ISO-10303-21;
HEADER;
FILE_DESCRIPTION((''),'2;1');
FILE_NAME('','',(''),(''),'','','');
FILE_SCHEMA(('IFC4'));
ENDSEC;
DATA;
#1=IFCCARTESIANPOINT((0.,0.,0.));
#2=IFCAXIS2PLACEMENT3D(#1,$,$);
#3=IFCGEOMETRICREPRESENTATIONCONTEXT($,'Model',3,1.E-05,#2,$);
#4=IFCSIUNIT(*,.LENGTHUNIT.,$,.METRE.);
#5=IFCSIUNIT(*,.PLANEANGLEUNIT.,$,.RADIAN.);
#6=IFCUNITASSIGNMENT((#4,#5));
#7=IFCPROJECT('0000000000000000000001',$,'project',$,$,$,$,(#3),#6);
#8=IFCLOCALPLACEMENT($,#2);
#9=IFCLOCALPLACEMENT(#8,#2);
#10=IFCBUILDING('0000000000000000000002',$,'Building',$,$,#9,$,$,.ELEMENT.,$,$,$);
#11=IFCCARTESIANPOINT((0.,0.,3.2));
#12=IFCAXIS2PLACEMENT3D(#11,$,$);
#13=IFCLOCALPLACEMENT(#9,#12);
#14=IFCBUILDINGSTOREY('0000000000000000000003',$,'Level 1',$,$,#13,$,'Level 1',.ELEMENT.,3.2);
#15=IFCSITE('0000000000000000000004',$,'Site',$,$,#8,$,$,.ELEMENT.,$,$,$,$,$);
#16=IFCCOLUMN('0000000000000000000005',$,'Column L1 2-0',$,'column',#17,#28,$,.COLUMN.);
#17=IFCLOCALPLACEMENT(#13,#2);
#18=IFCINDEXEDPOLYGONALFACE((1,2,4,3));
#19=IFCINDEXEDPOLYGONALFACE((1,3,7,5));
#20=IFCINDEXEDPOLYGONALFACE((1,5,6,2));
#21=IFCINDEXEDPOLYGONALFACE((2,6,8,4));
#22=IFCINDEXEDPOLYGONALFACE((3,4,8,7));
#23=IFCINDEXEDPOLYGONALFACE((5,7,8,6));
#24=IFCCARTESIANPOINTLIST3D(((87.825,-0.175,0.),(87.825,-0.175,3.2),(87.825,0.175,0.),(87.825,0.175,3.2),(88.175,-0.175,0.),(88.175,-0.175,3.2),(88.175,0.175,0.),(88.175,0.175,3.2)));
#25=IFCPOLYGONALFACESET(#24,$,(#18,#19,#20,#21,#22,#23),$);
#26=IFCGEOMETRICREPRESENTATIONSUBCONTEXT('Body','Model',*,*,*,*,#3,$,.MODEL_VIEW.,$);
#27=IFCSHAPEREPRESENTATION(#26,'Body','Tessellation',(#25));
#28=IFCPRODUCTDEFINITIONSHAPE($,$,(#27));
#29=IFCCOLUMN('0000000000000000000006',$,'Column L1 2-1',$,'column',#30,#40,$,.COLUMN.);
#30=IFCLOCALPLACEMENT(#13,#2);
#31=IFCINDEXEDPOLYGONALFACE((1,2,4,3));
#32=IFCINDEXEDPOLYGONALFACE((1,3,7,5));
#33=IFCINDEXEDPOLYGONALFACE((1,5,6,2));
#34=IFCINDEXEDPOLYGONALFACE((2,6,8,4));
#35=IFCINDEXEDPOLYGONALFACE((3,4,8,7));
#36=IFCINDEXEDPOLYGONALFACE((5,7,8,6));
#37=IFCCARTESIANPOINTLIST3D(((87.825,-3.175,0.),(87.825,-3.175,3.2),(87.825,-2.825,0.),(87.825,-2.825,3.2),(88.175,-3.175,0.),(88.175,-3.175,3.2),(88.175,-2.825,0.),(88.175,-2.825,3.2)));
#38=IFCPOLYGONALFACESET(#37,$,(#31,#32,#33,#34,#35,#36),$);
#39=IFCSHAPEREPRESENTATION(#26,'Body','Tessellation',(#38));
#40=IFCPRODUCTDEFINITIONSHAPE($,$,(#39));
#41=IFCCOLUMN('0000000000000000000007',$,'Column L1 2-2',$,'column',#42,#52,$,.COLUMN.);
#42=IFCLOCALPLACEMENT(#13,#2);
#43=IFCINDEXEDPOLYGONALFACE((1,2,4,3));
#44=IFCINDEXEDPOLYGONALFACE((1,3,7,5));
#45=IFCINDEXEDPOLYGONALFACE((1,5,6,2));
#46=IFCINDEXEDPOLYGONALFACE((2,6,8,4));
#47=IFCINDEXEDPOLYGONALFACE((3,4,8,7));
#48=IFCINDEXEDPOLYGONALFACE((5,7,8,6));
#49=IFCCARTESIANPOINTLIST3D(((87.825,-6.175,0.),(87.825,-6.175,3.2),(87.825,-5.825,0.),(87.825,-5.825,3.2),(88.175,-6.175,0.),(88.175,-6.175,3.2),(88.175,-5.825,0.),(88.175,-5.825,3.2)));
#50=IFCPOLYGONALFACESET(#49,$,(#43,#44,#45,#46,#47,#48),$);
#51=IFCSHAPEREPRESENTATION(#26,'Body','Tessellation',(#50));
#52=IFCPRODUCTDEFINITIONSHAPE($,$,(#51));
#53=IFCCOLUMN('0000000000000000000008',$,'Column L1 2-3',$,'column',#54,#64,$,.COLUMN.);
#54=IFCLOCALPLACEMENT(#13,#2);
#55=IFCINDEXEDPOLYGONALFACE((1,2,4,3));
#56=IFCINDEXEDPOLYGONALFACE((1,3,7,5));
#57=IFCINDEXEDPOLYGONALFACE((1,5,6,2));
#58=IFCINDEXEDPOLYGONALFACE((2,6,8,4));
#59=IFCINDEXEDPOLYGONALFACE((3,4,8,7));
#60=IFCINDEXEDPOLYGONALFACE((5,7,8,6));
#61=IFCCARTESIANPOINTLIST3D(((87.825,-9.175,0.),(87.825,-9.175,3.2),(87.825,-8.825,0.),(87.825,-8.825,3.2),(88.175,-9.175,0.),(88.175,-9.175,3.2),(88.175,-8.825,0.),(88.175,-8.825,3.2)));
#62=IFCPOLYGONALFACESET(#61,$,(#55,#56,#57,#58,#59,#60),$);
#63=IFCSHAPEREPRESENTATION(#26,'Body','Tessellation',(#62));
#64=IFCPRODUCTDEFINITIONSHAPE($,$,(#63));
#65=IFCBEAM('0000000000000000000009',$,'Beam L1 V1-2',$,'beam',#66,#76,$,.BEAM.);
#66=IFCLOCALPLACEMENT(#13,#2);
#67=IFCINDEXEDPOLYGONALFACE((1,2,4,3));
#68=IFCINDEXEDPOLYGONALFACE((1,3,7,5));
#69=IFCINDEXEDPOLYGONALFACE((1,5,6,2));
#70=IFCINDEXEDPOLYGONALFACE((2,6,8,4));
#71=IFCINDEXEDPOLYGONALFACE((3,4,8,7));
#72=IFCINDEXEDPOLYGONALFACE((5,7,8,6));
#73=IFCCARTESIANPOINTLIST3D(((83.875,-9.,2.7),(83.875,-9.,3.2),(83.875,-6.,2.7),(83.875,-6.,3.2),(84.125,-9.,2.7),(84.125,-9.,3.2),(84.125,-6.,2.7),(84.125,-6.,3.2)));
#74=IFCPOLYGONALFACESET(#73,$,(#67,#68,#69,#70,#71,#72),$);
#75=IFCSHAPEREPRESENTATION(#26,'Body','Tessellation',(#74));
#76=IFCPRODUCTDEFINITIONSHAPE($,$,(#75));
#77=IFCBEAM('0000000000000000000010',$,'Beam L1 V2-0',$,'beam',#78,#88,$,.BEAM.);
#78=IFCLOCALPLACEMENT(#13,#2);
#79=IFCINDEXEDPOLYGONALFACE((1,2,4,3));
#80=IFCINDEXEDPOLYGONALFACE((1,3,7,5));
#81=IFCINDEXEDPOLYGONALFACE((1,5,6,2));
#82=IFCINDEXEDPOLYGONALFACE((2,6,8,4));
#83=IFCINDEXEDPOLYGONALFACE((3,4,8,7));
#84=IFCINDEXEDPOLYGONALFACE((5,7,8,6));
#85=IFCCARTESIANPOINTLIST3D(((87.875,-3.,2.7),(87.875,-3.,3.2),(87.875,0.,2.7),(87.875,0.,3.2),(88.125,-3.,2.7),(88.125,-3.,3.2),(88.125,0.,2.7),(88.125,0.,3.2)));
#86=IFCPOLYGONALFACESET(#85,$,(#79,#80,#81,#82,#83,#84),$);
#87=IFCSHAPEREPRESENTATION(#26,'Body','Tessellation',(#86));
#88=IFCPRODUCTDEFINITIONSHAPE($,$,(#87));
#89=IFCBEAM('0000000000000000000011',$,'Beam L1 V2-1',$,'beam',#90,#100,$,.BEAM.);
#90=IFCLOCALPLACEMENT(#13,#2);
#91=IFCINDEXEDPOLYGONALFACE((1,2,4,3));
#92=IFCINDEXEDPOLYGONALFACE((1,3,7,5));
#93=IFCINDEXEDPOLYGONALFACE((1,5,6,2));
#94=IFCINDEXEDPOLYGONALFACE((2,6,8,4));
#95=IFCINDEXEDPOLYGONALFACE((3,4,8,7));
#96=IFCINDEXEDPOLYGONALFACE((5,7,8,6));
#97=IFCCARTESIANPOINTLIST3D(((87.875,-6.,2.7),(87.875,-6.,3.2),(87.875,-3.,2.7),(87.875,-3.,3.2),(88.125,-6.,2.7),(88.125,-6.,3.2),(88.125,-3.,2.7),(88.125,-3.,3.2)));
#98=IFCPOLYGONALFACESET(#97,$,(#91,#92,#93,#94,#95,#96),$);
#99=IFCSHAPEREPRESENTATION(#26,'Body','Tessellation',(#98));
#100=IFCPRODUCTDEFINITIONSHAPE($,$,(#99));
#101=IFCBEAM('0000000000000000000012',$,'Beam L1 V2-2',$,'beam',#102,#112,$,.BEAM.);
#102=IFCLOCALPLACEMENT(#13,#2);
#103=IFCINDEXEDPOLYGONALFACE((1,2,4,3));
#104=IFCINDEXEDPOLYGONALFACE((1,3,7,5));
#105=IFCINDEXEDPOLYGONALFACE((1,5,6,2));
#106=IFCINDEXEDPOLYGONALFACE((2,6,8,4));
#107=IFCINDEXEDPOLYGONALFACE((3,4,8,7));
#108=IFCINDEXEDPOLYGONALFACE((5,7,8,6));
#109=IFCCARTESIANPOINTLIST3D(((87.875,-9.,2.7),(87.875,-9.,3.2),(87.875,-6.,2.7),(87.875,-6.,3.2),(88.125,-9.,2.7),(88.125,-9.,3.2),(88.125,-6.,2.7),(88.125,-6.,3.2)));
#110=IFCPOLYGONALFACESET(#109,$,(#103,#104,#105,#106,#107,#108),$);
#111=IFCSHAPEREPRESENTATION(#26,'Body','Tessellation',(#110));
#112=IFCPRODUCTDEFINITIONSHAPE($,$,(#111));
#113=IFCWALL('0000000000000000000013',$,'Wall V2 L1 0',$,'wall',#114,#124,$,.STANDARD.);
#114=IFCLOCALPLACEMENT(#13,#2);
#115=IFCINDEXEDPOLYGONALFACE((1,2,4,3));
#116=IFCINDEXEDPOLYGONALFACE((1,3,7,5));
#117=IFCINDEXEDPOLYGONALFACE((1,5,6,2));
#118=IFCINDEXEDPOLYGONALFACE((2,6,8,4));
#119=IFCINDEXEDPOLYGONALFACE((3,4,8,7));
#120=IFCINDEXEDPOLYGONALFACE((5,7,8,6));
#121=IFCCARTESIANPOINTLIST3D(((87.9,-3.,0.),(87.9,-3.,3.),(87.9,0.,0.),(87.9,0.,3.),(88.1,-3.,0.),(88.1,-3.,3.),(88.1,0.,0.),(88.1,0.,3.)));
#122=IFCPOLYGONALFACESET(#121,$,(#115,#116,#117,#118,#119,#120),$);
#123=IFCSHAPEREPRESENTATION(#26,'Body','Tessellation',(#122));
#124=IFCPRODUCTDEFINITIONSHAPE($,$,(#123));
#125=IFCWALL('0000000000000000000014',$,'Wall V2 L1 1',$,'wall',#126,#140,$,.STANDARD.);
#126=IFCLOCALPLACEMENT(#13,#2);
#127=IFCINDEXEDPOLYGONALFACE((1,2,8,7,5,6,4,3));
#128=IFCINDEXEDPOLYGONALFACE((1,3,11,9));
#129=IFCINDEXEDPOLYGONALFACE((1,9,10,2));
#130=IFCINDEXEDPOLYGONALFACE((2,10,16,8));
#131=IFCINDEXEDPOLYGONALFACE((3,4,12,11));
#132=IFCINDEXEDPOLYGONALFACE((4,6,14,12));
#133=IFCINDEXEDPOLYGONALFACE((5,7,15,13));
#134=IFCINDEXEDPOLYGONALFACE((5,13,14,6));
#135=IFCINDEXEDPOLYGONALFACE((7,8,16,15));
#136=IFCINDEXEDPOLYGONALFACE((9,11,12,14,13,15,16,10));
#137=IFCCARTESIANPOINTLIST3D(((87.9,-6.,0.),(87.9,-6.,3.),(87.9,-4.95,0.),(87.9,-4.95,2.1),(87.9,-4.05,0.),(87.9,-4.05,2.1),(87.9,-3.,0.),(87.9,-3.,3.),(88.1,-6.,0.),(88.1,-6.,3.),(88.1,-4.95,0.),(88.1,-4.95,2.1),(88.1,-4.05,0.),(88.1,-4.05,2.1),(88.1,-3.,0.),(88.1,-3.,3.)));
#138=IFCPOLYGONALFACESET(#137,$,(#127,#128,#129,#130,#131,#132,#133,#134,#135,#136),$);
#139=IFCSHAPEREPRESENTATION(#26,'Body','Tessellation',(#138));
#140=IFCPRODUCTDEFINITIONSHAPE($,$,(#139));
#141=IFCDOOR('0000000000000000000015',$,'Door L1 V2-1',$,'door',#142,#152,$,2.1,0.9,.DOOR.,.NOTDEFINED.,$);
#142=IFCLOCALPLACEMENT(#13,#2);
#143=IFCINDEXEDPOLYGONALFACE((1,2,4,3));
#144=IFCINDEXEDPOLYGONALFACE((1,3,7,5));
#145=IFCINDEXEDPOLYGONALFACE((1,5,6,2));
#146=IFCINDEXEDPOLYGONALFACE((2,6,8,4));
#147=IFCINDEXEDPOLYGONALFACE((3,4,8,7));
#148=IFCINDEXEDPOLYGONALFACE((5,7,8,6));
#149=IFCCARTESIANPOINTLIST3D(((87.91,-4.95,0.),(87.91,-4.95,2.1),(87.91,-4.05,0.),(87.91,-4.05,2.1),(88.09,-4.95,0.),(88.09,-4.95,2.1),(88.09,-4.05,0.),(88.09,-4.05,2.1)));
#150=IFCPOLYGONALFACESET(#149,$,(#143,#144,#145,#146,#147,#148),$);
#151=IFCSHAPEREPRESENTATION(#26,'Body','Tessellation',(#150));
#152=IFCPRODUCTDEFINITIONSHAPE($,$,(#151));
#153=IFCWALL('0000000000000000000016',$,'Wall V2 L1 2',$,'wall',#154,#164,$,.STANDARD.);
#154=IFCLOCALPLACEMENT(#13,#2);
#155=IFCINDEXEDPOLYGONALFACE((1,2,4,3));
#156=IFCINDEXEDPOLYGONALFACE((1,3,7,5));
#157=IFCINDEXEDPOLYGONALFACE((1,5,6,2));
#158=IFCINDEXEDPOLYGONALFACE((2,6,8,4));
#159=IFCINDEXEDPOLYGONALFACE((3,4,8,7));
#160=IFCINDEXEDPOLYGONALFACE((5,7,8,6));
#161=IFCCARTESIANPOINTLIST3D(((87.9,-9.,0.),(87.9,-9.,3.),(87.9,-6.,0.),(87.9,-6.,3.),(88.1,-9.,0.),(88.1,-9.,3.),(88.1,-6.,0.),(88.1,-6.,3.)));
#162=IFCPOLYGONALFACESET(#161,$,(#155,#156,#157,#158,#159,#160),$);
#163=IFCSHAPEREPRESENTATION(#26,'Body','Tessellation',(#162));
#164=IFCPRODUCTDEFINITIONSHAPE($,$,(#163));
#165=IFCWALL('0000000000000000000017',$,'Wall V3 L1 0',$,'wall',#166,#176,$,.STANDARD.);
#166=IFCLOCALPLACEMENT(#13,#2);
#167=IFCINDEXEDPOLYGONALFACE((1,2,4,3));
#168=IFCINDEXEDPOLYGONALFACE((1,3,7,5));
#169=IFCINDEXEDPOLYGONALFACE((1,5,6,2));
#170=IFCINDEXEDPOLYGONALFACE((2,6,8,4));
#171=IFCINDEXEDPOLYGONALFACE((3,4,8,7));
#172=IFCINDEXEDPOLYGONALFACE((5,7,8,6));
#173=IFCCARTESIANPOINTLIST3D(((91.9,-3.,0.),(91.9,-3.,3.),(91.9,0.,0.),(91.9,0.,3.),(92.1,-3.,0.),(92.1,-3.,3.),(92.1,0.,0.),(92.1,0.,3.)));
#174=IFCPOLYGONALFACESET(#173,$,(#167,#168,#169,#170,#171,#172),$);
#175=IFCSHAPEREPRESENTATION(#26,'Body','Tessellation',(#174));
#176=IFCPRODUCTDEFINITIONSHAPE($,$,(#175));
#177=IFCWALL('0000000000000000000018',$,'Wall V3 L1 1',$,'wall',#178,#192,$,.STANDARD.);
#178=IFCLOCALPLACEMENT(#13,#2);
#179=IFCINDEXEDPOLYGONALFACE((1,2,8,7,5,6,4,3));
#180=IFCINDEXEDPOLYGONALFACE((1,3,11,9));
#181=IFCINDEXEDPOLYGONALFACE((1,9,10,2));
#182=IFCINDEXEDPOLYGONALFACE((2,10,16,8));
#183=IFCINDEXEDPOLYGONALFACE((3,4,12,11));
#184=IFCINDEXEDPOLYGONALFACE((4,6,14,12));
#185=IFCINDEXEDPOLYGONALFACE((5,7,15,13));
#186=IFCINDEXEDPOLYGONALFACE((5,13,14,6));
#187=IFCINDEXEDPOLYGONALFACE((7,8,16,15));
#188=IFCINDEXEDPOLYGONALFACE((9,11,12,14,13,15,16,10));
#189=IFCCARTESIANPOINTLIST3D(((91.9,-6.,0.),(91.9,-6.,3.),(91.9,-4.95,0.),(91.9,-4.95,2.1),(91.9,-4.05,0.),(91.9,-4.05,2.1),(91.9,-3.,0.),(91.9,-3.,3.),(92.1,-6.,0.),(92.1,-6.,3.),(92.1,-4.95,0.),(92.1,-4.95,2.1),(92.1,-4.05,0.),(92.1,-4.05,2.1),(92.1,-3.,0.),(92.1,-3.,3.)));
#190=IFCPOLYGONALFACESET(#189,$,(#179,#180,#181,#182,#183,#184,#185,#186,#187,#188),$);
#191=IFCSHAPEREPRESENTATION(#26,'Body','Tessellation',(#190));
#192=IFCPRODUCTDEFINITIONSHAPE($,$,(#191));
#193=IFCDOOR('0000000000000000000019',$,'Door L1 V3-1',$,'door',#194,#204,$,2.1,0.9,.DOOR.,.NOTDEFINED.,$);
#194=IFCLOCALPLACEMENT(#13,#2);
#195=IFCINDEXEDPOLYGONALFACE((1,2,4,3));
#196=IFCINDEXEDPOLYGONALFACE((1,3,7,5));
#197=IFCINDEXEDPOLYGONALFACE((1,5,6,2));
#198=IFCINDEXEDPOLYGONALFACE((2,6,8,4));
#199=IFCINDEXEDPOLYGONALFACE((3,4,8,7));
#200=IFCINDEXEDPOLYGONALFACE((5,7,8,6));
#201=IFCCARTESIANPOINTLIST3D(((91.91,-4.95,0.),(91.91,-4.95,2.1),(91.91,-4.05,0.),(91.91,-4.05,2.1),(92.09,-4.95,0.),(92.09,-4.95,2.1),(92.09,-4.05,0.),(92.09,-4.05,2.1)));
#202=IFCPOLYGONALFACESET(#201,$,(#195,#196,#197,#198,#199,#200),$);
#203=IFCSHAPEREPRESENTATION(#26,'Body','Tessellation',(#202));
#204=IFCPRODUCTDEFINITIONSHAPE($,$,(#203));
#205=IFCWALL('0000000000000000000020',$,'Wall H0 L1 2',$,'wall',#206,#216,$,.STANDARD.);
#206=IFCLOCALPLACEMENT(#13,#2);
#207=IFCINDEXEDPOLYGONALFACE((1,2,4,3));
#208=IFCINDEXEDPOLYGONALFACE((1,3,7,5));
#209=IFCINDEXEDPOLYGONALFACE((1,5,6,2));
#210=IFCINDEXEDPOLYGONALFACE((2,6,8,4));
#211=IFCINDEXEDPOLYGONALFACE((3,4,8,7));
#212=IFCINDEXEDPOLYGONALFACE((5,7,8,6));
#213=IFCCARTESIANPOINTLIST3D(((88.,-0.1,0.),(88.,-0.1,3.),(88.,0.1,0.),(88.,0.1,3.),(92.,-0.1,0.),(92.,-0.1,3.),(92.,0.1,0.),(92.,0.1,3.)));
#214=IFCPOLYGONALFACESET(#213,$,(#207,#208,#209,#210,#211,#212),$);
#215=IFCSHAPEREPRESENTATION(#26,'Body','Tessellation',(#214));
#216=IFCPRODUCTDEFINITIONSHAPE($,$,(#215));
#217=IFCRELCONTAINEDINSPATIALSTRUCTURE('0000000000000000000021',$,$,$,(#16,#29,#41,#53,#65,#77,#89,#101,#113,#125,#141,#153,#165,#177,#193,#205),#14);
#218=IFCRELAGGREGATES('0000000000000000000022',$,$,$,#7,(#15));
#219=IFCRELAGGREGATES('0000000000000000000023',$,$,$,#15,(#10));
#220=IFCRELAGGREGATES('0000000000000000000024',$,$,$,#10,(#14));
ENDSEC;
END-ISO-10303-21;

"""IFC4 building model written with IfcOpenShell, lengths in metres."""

from ifc_helpers import new_model, si_unit, frame, frame_2d, origin, origin_2d, place, context, subcontext, project, spatial, rectangle, extrude, element, fill, save


model = new_model("IFC4")

# Units and contexts
model_context = context("Model", 3, precision=1e-05, world=origin())
body_context = subcontext(model_context, "Body", "Model", "MODEL_VIEW")
ifc_project = project(units=[si_unit("LENGTHUNIT", "METRE"), si_unit("PLANEANGLEUNIT", "RADIAN")], contexts=[model_context])

# Site, building, storey
site_placement = place(None, origin())
site = spatial("IfcSite", under=ifc_project, at=site_placement, Name="Site", CompositionType="ELEMENT")
building_placement = place(site_placement, origin())
building = spatial("IfcBuilding", under=site, at=building_placement, Name="Building", CompositionType="ELEMENT")
storey_placement = place(building_placement, frame((0.0, 0.0, 3.2)))
storey = spatial("IfcBuildingStorey", under=building, at=storey_placement, Name="Level 1", LongName="Level 1", CompositionType="ELEMENT", Elevation=3.2)

# Columns
for number, where, name in (
    (1, (88.0, 0.0, 0.0), "Column L1 2-0"),
    (2, (88.0, -3.0, 0.0), "Column L1 2-1"),
    (3, (88.0, -6.0, 0.0), "Column L1 2-2"),
    (4, (88.0, -9.0, 0.0), "Column L1 2-3"),
):
    element("IfcColumn", number, at=place(storey_placement, frame(where)), inside=storey, Name=name, ObjectType="column", PredefinedType="COLUMN", context=body_context, shape_type="SweptSolid", body=[
        extrude(rectangle(XDim=0.35, YDim=0.35, at=origin_2d()), origin(), (0.0, 0.0, 1.0), 3.2),
    ])

# Beams
for number, where, z_axis, x_axis, name in (
    (5, (84.0, -6.0, 2.95), (0.0, -1.0, 0.0), (0.0, 0.0, 1.0), "Beam L1 V1-2"),
    (6, (88.0, 0.0, 2.95), (0.0, -1.0, 0.0), (0.0, 0.0, 1.0), "Beam L1 V2-0"),
    (7, (88.0, -3.0, 2.95), (0.0, -1.0, 0.0), (0.0, 0.0, 1.0), "Beam L1 V2-1"),
    (8, (88.0, -6.0, 2.95), (0.0, -1.0, 0.0), (0.0, 0.0, 1.0), "Beam L1 V2-2"),
):
    element("IfcBeam", number, at=place(storey_placement, frame(where, z_axis=z_axis, x_axis=x_axis)), inside=storey, Name=name, ObjectType="beam", PredefinedType="BEAM", context=body_context, shape_type="SweptSolid", body=[
        extrude(rectangle(XDim=0.5, YDim=0.25, at=origin_2d()), origin(), (0.0, 0.0, 1.0), 3.0),
    ])

# Wall
wall_1_placement = place(storey_placement, frame((88.0, 0.0, 0.0), z_axis=(0.0, 0.0, 1.0), x_axis=(0.0, -1.0, 0.0)))
element("IfcWall", 9, at=wall_1_placement, inside=storey, Name="Wall V2 L1 0", ObjectType="wall", PredefinedType="STANDARD", context=body_context, shape_type="SweptSolid", body=[
    extrude(rectangle(XDim=3.0, YDim=0.2, at=frame_2d((1.5, 0.0))), origin(), (0.0, 0.0, 1.0), 3.0),
])

# Wall, opening, door
wall_2_placement = place(storey_placement, frame((88.0, -3.0, 0.0), z_axis=(0.0, 0.0, 1.0), x_axis=(0.0, -1.0, 0.0)))
wall_2 = element("IfcWall", 10, at=wall_2_placement, inside=storey, Name="Wall V2 L1 1", ObjectType="wall", PredefinedType="STANDARD", context=body_context, shape_type="SweptSolid", body=[
    extrude(rectangle(XDim=3.0, YDim=0.2, at=frame_2d((1.5, 0.0))), origin(), (0.0, 0.0, 1.0), 3.0),
])
opening_1_placement = place(storey_placement, frame((88.0, -4.5, 0.0), z_axis=(0.0, 0.0, 1.0), x_axis=(0.0, -1.0, 0.0)))
opening_1 = element("IfcOpeningElement", 11, at=opening_1_placement, cuts=wall_2, ObjectType="Opening", PredefinedType="OPENING", context=body_context, shape_type="SweptSolid", body=[
    extrude(rectangle(XDim=0.9, YDim=0.22, at=origin_2d()), origin(), (0.0, 0.0, 1.0), 2.1),
])
door_1_placement = place(storey_placement, frame((88.0, -4.5, 0.0), z_axis=(0.0, 0.0, 1.0), x_axis=(0.0, -1.0, 0.0)))
door_1 = element("IfcDoor", 12, at=door_1_placement, inside=storey, Name="Door L1 V2-1", ObjectType="door", OperationType="NOTDEFINED", OverallHeight=2.1, OverallWidth=0.9, PredefinedType="DOOR", context=body_context, shape_type="SweptSolid", body=[
    extrude(rectangle(XDim=0.9, YDim=0.18, at=origin_2d()), origin(), (0.0, 0.0, 1.0), 2.1),
])
fill(opening_1, door_1)

# Walls
for number, where, z_axis, x_axis, name in (
    (13, (88.0, -6.0, 0.0), (0.0, 0.0, 1.0), (0.0, -1.0, 0.0), "Wall V2 L1 2"),
    (14, (92.0, 0.0, 0.0), (0.0, 0.0, 1.0), (0.0, -1.0, 0.0), "Wall V3 L1 0"),
):
    element("IfcWall", number, at=place(storey_placement, frame(where, z_axis=z_axis, x_axis=x_axis)), inside=storey, Name=name, ObjectType="wall", PredefinedType="STANDARD", context=body_context, shape_type="SweptSolid", body=[
        extrude(rectangle(XDim=3.0, YDim=0.2, at=frame_2d((1.5, 0.0))), origin(), (0.0, 0.0, 1.0), 3.0),
    ])

# Wall, opening, door
wall_3_placement = place(storey_placement, frame((92.0, -3.0, 0.0), z_axis=(0.0, 0.0, 1.0), x_axis=(0.0, -1.0, 0.0)))
wall_3 = element("IfcWall", 15, at=wall_3_placement, inside=storey, Name="Wall V3 L1 1", ObjectType="wall", PredefinedType="STANDARD", context=body_context, shape_type="SweptSolid", body=[
    extrude(rectangle(XDim=3.0, YDim=0.2, at=frame_2d((1.5, 0.0))), origin(), (0.0, 0.0, 1.0), 3.0),
])
opening_2_placement = place(storey_placement, frame((92.0, -4.5, 0.0), z_axis=(0.0, 0.0, 1.0), x_axis=(0.0, -1.0, 0.0)))
opening_2 = element("IfcOpeningElement", 16, at=opening_2_placement, cuts=wall_3, ObjectType="Opening", PredefinedType="OPENING", context=body_context, shape_type="SweptSolid", body=[
    extrude(rectangle(XDim=0.9, YDim=0.22, at=origin_2d()), origin(), (0.0, 0.0, 1.0), 2.1),
])
door_2_placement = place(storey_placement, frame((92.0, -4.5, 0.0), z_axis=(0.0, 0.0, 1.0), x_axis=(0.0, -1.0, 0.0)))
door_2 = element("IfcDoor", 17, at=door_2_placement, inside=storey, Name="Door L1 V3-1", ObjectType="door", OperationType="NOTDEFINED", OverallHeight=2.1, OverallWidth=0.9, PredefinedType="DOOR", context=body_context, shape_type="SweptSolid", body=[
    extrude(rectangle(XDim=0.9, YDim=0.18, at=origin_2d()), origin(), (0.0, 0.0, 1.0), 2.1),
])
fill(opening_2, door_2)

# Wall
wall_4_placement = place(storey_placement, frame((88.0, 0.0, 0.0), z_axis=(0.0, 0.0, 1.0), x_axis=(1.0, 0.0, 0.0)))
element("IfcWall", 18, at=wall_4_placement, inside=storey, Name="Wall H0 L1 2", ObjectType="wall", PredefinedType="STANDARD", context=body_context, shape_type="SweptSolid", body=[
    extrude(rectangle(XDim=4.0, YDim=0.2, at=frame_2d((2.0, 0.0))), origin(), (0.0, 0.0, 1.0), 3.0),
])

save(model, "model.ifc")
